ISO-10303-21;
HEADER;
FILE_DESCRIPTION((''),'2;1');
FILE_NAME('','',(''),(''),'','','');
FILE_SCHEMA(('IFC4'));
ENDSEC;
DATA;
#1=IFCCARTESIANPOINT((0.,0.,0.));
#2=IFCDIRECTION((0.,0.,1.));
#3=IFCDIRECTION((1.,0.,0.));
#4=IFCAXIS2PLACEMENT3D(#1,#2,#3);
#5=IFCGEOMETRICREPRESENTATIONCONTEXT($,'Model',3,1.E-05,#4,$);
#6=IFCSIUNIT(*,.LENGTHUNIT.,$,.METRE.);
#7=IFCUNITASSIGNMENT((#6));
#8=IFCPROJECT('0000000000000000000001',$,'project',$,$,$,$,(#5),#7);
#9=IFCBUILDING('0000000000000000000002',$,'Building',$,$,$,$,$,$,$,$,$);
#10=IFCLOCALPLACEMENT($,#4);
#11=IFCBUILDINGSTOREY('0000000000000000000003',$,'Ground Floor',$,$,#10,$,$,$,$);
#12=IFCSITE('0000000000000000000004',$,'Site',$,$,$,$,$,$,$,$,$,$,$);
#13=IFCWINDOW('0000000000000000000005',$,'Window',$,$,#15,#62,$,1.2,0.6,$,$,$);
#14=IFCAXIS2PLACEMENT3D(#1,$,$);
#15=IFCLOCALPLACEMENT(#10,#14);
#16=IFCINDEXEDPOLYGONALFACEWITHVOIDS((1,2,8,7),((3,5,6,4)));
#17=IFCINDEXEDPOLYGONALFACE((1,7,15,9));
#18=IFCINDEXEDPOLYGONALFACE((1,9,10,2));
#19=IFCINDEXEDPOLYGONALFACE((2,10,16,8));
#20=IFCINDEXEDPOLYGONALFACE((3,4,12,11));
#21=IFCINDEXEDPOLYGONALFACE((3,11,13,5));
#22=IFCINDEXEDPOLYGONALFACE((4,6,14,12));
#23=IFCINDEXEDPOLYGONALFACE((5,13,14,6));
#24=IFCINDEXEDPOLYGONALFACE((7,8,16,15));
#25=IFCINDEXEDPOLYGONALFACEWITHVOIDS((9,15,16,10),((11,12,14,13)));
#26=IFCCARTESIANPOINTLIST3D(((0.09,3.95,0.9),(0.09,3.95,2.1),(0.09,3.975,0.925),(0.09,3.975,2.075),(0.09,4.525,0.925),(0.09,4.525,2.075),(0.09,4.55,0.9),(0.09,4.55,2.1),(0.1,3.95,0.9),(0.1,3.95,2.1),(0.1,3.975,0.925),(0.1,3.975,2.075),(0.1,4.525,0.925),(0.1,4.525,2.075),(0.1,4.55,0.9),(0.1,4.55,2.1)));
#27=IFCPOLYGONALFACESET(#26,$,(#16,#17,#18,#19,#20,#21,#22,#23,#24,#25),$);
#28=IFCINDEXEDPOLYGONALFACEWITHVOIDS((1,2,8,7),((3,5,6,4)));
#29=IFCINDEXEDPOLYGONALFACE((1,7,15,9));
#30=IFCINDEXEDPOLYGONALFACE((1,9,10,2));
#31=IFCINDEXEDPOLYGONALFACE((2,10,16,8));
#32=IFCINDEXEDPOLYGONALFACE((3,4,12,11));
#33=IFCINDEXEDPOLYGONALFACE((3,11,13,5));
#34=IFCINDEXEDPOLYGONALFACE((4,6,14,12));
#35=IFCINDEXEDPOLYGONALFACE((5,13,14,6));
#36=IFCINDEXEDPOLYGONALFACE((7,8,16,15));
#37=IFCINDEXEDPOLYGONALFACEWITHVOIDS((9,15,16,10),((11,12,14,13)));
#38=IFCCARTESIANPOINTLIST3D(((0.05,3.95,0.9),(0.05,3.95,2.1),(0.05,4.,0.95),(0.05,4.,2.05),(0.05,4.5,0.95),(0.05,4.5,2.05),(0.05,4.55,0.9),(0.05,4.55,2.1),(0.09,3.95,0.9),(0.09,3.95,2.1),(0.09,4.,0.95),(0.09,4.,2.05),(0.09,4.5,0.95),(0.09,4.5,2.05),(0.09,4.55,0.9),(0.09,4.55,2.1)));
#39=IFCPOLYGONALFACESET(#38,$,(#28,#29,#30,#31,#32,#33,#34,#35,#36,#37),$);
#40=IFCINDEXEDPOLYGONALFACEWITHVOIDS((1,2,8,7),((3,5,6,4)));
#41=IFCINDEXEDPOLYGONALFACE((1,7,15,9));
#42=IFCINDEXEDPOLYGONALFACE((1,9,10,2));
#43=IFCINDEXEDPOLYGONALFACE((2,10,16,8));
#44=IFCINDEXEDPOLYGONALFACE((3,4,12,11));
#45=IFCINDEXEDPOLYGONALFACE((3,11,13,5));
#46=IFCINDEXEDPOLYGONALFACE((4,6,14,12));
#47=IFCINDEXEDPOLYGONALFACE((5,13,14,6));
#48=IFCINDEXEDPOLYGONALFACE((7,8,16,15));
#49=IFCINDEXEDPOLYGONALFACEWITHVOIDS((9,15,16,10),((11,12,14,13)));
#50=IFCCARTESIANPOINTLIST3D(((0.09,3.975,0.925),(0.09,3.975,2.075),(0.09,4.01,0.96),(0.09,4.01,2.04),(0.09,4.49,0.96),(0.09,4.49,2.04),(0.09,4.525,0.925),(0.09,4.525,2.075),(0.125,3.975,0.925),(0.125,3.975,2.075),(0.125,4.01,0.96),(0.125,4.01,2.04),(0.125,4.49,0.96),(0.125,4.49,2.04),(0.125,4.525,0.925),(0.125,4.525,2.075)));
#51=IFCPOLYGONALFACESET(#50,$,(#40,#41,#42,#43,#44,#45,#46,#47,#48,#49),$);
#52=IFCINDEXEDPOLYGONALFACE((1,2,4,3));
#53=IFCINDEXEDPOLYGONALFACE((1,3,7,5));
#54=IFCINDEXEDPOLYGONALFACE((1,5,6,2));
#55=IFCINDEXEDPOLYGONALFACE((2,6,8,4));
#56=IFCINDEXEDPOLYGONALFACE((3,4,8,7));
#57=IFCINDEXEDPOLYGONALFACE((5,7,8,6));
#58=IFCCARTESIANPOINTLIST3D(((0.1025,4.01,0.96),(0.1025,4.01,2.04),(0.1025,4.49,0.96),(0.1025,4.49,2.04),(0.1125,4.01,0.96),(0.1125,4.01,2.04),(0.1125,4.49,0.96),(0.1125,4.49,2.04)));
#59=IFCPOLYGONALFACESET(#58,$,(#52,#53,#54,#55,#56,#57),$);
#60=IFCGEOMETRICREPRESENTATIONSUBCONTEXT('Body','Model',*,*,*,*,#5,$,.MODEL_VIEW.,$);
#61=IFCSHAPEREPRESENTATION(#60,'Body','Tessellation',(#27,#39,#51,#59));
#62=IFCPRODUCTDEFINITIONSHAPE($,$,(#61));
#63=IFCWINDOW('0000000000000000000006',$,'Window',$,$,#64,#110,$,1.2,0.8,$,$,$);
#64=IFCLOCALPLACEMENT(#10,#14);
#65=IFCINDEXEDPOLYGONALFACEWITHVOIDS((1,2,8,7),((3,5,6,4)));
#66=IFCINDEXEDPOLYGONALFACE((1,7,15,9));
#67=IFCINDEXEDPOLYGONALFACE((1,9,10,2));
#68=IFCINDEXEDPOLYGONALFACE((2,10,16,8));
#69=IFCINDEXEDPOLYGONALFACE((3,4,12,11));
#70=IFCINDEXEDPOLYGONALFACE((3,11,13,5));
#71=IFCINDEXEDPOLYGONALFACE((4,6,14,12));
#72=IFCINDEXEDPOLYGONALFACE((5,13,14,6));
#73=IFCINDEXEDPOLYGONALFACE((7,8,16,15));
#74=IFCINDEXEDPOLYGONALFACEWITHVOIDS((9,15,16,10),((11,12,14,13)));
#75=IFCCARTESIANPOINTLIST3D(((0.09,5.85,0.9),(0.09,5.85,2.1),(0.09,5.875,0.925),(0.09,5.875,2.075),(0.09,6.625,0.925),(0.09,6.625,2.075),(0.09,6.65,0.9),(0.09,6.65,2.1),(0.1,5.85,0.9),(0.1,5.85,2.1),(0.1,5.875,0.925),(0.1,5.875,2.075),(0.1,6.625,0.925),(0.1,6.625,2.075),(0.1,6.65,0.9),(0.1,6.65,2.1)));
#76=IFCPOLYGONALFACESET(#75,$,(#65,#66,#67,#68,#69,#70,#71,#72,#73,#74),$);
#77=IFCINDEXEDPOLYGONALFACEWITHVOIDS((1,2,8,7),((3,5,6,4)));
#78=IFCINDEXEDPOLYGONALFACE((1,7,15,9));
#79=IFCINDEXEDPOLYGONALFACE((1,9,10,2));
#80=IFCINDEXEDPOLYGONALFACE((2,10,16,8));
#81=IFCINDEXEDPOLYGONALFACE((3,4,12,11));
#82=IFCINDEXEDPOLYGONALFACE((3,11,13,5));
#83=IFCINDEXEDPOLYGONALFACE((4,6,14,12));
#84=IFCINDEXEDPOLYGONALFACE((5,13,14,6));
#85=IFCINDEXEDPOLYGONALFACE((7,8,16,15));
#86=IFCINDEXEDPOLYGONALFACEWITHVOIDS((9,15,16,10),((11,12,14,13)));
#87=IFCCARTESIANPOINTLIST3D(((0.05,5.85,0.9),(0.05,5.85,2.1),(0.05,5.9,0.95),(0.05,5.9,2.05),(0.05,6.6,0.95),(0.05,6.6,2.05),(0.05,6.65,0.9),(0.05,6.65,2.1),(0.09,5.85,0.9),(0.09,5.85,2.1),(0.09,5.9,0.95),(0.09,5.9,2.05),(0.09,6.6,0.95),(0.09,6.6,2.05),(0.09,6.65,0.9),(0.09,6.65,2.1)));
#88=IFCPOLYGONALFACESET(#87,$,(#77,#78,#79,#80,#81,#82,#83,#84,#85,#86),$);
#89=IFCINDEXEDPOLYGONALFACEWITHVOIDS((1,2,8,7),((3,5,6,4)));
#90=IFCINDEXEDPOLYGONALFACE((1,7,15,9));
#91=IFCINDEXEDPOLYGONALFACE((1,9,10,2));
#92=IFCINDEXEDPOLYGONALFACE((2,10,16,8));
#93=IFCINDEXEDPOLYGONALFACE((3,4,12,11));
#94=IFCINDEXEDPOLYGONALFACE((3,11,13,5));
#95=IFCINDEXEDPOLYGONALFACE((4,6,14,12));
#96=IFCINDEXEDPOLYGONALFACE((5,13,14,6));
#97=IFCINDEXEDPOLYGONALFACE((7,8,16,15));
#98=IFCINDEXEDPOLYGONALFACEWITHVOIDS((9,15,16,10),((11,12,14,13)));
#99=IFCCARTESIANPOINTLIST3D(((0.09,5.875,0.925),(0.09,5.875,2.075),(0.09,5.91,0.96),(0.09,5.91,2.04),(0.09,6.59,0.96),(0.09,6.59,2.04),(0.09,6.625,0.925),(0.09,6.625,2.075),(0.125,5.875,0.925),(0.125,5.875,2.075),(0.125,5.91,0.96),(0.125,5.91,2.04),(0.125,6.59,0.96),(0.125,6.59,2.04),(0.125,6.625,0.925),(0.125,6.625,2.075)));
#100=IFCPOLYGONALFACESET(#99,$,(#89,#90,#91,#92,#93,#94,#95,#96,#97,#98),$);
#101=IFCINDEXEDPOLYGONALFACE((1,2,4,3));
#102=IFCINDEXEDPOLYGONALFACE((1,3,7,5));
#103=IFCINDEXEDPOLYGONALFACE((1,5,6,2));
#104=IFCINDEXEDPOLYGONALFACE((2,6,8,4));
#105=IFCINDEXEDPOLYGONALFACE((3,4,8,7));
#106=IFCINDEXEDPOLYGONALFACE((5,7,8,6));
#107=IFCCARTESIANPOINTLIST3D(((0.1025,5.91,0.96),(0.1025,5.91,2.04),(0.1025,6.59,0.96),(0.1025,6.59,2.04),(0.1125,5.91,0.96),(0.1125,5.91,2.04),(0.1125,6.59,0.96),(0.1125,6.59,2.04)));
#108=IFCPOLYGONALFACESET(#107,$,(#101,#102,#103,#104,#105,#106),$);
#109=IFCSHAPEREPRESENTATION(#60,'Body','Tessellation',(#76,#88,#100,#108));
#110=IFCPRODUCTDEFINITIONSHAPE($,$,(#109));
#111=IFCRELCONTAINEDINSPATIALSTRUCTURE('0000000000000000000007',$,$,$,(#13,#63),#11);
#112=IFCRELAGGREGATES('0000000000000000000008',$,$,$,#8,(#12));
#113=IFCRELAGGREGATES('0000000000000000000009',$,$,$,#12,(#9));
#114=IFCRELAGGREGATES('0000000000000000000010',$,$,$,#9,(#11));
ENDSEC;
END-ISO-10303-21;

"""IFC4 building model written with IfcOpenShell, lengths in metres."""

from ifc_helpers import new_model, si_unit, frame, origin_with_axes, place, context, subcontext, project, spatial, line, indexed_curve, outline, extrude, element, save


model = new_model("IFC4")

# Units and contexts
model_context = context("Model", 3, precision=1e-05, world=origin_with_axes())
body_context = subcontext(model_context, "Body", "Model", "MODEL_VIEW")
ifc_project = project(units=[si_unit("LENGTHUNIT", "METRE")], contexts=[model_context])

# Site, building, storey
site = spatial("IfcSite", under=ifc_project, Name="Site")
building = spatial("IfcBuilding", under=site, Name="Building")
storey_placement = place(None, origin_with_axes())
storey = spatial("IfcBuildingStorey", under=building, at=storey_placement, Name="Ground Floor")

# Windows
window_1_placement = place(storey_placement, frame((0.0, 4.55, 0.9), z_axis=(0.0, 0.0, 1.0), x_axis=(0.0, -1.0, 0.0)))
element("IfcWindow", 1, at=window_1_placement, inside=storey, Name="Window", OverallHeight=1.2, OverallWidth=0.6, context=body_context, shape_type="SweptSolid", body=[
    extrude(outline(indexed_curve([(0.0, 0.0), (0.6, 0.0), (0.6, 1.2), (0.0, 1.2)], segments=[line(1, 2, 3, 4, 1)]), holes=[indexed_curve([(0.025, 0.025), (0.575, 0.025), (0.575, 1.175), (0.025, 1.175)], segments=[line(1, 2, 3, 4, 1)])]), frame((0.0, 0.09, 0.0), z_axis=(0.0, -1.0, 0.0), x_axis=(1.0, 0.0, 0.0)), (0.0, 0.0, -1.0), 0.01),
    extrude(outline(indexed_curve([(0.0, 0.0), (0.6, 0.0), (0.6, 1.2), (0.0, 1.2)], segments=[line(1, 2, 3, 4, 1)]), holes=[indexed_curve([(0.05, 0.05), (0.55, 0.05), (0.55, 1.15), (0.05, 1.15)], segments=[line(1, 2, 3, 4, 1)])]), frame((0.0, 0.05, 0.0), z_axis=(0.0, -1.0, 0.0), x_axis=(1.0, 0.0, 0.0)), (0.0, 0.0, -1.0), 0.04),
    extrude(outline(indexed_curve([(0.0, 0.0), (0.55, 0.0), (0.55, 1.15), (0.0, 1.15)], segments=[line(1, 2, 3, 4, 1)]), holes=[indexed_curve([(0.035, 0.035), (0.515, 0.035), (0.515, 1.115), (0.035, 1.115)], segments=[line(1, 2, 3, 4, 1)])]), frame((0.025, 0.09, 0.025), z_axis=(0.0, -1.0, 0.0), x_axis=(1.0, 0.0, 0.0)), (0.0, 0.0, -1.0), 0.035),
    extrude(outline(indexed_curve([(0.035, 0.035), (0.515, 0.035), (0.515, 1.115), (0.035, 1.115)], segments=[line(1, 2, 3, 4, 1)])), frame((0.025, 0.1025, 0.025), z_axis=(0.0, -1.0, 0.0), x_axis=(1.0, 0.0, 0.0)), (0.0, 0.0, -1.0), 0.01),
])
window_2_placement = place(storey_placement, frame((0.0, 6.65, 0.9), z_axis=(0.0, 0.0, 1.0), x_axis=(0.0, -1.0, 0.0)))
element("IfcWindow", 2, at=window_2_placement, inside=storey, Name="Window", OverallHeight=1.2, OverallWidth=0.8, context=body_context, shape_type="SweptSolid", body=[
    extrude(outline(indexed_curve([(0.0, 0.0), (0.8, 0.0), (0.8, 1.2), (0.0, 1.2)], segments=[line(1, 2, 3, 4, 1)]), holes=[indexed_curve([(0.025, 0.025), (0.775, 0.025), (0.775, 1.175), (0.025, 1.175)], segments=[line(1, 2, 3, 4, 1)])]), frame((0.0, 0.09, 0.0), z_axis=(0.0, -1.0, 0.0), x_axis=(1.0, 0.0, 0.0)), (0.0, 0.0, -1.0), 0.01),
    extrude(outline(indexed_curve([(0.0, 0.0), (0.8, 0.0), (0.8, 1.2), (0.0, 1.2)], segments=[line(1, 2, 3, 4, 1)]), holes=[indexed_curve([(0.05, 0.05), (0.75, 0.05), (0.75, 1.15), (0.05, 1.15)], segments=[line(1, 2, 3, 4, 1)])]), frame((0.0, 0.05, 0.0), z_axis=(0.0, -1.0, 0.0), x_axis=(1.0, 0.0, 0.0)), (0.0, 0.0, -1.0), 0.04),
    extrude(outline(indexed_curve([(0.0, 0.0), (0.75, 0.0), (0.75, 1.15), (0.0, 1.15)], segments=[line(1, 2, 3, 4, 1)]), holes=[indexed_curve([(0.035, 0.035), (0.715, 0.035), (0.715, 1.115), (0.035, 1.115)], segments=[line(1, 2, 3, 4, 1)])]), frame((0.025, 0.09, 0.025), z_axis=(0.0, -1.0, 0.0), x_axis=(1.0, 0.0, 0.0)), (0.0, 0.0, -1.0), 0.035),
    extrude(outline(indexed_curve([(0.035, 0.035), (0.715, 0.035), (0.715, 1.115), (0.035, 1.115)], segments=[line(1, 2, 3, 4, 1)])), frame((0.025, 0.1025, 0.025), z_axis=(0.0, -1.0, 0.0), x_axis=(1.0, 0.0, 0.0)), (0.0, 0.0, -1.0), 0.01),
])

save(model, "model.ifc")
